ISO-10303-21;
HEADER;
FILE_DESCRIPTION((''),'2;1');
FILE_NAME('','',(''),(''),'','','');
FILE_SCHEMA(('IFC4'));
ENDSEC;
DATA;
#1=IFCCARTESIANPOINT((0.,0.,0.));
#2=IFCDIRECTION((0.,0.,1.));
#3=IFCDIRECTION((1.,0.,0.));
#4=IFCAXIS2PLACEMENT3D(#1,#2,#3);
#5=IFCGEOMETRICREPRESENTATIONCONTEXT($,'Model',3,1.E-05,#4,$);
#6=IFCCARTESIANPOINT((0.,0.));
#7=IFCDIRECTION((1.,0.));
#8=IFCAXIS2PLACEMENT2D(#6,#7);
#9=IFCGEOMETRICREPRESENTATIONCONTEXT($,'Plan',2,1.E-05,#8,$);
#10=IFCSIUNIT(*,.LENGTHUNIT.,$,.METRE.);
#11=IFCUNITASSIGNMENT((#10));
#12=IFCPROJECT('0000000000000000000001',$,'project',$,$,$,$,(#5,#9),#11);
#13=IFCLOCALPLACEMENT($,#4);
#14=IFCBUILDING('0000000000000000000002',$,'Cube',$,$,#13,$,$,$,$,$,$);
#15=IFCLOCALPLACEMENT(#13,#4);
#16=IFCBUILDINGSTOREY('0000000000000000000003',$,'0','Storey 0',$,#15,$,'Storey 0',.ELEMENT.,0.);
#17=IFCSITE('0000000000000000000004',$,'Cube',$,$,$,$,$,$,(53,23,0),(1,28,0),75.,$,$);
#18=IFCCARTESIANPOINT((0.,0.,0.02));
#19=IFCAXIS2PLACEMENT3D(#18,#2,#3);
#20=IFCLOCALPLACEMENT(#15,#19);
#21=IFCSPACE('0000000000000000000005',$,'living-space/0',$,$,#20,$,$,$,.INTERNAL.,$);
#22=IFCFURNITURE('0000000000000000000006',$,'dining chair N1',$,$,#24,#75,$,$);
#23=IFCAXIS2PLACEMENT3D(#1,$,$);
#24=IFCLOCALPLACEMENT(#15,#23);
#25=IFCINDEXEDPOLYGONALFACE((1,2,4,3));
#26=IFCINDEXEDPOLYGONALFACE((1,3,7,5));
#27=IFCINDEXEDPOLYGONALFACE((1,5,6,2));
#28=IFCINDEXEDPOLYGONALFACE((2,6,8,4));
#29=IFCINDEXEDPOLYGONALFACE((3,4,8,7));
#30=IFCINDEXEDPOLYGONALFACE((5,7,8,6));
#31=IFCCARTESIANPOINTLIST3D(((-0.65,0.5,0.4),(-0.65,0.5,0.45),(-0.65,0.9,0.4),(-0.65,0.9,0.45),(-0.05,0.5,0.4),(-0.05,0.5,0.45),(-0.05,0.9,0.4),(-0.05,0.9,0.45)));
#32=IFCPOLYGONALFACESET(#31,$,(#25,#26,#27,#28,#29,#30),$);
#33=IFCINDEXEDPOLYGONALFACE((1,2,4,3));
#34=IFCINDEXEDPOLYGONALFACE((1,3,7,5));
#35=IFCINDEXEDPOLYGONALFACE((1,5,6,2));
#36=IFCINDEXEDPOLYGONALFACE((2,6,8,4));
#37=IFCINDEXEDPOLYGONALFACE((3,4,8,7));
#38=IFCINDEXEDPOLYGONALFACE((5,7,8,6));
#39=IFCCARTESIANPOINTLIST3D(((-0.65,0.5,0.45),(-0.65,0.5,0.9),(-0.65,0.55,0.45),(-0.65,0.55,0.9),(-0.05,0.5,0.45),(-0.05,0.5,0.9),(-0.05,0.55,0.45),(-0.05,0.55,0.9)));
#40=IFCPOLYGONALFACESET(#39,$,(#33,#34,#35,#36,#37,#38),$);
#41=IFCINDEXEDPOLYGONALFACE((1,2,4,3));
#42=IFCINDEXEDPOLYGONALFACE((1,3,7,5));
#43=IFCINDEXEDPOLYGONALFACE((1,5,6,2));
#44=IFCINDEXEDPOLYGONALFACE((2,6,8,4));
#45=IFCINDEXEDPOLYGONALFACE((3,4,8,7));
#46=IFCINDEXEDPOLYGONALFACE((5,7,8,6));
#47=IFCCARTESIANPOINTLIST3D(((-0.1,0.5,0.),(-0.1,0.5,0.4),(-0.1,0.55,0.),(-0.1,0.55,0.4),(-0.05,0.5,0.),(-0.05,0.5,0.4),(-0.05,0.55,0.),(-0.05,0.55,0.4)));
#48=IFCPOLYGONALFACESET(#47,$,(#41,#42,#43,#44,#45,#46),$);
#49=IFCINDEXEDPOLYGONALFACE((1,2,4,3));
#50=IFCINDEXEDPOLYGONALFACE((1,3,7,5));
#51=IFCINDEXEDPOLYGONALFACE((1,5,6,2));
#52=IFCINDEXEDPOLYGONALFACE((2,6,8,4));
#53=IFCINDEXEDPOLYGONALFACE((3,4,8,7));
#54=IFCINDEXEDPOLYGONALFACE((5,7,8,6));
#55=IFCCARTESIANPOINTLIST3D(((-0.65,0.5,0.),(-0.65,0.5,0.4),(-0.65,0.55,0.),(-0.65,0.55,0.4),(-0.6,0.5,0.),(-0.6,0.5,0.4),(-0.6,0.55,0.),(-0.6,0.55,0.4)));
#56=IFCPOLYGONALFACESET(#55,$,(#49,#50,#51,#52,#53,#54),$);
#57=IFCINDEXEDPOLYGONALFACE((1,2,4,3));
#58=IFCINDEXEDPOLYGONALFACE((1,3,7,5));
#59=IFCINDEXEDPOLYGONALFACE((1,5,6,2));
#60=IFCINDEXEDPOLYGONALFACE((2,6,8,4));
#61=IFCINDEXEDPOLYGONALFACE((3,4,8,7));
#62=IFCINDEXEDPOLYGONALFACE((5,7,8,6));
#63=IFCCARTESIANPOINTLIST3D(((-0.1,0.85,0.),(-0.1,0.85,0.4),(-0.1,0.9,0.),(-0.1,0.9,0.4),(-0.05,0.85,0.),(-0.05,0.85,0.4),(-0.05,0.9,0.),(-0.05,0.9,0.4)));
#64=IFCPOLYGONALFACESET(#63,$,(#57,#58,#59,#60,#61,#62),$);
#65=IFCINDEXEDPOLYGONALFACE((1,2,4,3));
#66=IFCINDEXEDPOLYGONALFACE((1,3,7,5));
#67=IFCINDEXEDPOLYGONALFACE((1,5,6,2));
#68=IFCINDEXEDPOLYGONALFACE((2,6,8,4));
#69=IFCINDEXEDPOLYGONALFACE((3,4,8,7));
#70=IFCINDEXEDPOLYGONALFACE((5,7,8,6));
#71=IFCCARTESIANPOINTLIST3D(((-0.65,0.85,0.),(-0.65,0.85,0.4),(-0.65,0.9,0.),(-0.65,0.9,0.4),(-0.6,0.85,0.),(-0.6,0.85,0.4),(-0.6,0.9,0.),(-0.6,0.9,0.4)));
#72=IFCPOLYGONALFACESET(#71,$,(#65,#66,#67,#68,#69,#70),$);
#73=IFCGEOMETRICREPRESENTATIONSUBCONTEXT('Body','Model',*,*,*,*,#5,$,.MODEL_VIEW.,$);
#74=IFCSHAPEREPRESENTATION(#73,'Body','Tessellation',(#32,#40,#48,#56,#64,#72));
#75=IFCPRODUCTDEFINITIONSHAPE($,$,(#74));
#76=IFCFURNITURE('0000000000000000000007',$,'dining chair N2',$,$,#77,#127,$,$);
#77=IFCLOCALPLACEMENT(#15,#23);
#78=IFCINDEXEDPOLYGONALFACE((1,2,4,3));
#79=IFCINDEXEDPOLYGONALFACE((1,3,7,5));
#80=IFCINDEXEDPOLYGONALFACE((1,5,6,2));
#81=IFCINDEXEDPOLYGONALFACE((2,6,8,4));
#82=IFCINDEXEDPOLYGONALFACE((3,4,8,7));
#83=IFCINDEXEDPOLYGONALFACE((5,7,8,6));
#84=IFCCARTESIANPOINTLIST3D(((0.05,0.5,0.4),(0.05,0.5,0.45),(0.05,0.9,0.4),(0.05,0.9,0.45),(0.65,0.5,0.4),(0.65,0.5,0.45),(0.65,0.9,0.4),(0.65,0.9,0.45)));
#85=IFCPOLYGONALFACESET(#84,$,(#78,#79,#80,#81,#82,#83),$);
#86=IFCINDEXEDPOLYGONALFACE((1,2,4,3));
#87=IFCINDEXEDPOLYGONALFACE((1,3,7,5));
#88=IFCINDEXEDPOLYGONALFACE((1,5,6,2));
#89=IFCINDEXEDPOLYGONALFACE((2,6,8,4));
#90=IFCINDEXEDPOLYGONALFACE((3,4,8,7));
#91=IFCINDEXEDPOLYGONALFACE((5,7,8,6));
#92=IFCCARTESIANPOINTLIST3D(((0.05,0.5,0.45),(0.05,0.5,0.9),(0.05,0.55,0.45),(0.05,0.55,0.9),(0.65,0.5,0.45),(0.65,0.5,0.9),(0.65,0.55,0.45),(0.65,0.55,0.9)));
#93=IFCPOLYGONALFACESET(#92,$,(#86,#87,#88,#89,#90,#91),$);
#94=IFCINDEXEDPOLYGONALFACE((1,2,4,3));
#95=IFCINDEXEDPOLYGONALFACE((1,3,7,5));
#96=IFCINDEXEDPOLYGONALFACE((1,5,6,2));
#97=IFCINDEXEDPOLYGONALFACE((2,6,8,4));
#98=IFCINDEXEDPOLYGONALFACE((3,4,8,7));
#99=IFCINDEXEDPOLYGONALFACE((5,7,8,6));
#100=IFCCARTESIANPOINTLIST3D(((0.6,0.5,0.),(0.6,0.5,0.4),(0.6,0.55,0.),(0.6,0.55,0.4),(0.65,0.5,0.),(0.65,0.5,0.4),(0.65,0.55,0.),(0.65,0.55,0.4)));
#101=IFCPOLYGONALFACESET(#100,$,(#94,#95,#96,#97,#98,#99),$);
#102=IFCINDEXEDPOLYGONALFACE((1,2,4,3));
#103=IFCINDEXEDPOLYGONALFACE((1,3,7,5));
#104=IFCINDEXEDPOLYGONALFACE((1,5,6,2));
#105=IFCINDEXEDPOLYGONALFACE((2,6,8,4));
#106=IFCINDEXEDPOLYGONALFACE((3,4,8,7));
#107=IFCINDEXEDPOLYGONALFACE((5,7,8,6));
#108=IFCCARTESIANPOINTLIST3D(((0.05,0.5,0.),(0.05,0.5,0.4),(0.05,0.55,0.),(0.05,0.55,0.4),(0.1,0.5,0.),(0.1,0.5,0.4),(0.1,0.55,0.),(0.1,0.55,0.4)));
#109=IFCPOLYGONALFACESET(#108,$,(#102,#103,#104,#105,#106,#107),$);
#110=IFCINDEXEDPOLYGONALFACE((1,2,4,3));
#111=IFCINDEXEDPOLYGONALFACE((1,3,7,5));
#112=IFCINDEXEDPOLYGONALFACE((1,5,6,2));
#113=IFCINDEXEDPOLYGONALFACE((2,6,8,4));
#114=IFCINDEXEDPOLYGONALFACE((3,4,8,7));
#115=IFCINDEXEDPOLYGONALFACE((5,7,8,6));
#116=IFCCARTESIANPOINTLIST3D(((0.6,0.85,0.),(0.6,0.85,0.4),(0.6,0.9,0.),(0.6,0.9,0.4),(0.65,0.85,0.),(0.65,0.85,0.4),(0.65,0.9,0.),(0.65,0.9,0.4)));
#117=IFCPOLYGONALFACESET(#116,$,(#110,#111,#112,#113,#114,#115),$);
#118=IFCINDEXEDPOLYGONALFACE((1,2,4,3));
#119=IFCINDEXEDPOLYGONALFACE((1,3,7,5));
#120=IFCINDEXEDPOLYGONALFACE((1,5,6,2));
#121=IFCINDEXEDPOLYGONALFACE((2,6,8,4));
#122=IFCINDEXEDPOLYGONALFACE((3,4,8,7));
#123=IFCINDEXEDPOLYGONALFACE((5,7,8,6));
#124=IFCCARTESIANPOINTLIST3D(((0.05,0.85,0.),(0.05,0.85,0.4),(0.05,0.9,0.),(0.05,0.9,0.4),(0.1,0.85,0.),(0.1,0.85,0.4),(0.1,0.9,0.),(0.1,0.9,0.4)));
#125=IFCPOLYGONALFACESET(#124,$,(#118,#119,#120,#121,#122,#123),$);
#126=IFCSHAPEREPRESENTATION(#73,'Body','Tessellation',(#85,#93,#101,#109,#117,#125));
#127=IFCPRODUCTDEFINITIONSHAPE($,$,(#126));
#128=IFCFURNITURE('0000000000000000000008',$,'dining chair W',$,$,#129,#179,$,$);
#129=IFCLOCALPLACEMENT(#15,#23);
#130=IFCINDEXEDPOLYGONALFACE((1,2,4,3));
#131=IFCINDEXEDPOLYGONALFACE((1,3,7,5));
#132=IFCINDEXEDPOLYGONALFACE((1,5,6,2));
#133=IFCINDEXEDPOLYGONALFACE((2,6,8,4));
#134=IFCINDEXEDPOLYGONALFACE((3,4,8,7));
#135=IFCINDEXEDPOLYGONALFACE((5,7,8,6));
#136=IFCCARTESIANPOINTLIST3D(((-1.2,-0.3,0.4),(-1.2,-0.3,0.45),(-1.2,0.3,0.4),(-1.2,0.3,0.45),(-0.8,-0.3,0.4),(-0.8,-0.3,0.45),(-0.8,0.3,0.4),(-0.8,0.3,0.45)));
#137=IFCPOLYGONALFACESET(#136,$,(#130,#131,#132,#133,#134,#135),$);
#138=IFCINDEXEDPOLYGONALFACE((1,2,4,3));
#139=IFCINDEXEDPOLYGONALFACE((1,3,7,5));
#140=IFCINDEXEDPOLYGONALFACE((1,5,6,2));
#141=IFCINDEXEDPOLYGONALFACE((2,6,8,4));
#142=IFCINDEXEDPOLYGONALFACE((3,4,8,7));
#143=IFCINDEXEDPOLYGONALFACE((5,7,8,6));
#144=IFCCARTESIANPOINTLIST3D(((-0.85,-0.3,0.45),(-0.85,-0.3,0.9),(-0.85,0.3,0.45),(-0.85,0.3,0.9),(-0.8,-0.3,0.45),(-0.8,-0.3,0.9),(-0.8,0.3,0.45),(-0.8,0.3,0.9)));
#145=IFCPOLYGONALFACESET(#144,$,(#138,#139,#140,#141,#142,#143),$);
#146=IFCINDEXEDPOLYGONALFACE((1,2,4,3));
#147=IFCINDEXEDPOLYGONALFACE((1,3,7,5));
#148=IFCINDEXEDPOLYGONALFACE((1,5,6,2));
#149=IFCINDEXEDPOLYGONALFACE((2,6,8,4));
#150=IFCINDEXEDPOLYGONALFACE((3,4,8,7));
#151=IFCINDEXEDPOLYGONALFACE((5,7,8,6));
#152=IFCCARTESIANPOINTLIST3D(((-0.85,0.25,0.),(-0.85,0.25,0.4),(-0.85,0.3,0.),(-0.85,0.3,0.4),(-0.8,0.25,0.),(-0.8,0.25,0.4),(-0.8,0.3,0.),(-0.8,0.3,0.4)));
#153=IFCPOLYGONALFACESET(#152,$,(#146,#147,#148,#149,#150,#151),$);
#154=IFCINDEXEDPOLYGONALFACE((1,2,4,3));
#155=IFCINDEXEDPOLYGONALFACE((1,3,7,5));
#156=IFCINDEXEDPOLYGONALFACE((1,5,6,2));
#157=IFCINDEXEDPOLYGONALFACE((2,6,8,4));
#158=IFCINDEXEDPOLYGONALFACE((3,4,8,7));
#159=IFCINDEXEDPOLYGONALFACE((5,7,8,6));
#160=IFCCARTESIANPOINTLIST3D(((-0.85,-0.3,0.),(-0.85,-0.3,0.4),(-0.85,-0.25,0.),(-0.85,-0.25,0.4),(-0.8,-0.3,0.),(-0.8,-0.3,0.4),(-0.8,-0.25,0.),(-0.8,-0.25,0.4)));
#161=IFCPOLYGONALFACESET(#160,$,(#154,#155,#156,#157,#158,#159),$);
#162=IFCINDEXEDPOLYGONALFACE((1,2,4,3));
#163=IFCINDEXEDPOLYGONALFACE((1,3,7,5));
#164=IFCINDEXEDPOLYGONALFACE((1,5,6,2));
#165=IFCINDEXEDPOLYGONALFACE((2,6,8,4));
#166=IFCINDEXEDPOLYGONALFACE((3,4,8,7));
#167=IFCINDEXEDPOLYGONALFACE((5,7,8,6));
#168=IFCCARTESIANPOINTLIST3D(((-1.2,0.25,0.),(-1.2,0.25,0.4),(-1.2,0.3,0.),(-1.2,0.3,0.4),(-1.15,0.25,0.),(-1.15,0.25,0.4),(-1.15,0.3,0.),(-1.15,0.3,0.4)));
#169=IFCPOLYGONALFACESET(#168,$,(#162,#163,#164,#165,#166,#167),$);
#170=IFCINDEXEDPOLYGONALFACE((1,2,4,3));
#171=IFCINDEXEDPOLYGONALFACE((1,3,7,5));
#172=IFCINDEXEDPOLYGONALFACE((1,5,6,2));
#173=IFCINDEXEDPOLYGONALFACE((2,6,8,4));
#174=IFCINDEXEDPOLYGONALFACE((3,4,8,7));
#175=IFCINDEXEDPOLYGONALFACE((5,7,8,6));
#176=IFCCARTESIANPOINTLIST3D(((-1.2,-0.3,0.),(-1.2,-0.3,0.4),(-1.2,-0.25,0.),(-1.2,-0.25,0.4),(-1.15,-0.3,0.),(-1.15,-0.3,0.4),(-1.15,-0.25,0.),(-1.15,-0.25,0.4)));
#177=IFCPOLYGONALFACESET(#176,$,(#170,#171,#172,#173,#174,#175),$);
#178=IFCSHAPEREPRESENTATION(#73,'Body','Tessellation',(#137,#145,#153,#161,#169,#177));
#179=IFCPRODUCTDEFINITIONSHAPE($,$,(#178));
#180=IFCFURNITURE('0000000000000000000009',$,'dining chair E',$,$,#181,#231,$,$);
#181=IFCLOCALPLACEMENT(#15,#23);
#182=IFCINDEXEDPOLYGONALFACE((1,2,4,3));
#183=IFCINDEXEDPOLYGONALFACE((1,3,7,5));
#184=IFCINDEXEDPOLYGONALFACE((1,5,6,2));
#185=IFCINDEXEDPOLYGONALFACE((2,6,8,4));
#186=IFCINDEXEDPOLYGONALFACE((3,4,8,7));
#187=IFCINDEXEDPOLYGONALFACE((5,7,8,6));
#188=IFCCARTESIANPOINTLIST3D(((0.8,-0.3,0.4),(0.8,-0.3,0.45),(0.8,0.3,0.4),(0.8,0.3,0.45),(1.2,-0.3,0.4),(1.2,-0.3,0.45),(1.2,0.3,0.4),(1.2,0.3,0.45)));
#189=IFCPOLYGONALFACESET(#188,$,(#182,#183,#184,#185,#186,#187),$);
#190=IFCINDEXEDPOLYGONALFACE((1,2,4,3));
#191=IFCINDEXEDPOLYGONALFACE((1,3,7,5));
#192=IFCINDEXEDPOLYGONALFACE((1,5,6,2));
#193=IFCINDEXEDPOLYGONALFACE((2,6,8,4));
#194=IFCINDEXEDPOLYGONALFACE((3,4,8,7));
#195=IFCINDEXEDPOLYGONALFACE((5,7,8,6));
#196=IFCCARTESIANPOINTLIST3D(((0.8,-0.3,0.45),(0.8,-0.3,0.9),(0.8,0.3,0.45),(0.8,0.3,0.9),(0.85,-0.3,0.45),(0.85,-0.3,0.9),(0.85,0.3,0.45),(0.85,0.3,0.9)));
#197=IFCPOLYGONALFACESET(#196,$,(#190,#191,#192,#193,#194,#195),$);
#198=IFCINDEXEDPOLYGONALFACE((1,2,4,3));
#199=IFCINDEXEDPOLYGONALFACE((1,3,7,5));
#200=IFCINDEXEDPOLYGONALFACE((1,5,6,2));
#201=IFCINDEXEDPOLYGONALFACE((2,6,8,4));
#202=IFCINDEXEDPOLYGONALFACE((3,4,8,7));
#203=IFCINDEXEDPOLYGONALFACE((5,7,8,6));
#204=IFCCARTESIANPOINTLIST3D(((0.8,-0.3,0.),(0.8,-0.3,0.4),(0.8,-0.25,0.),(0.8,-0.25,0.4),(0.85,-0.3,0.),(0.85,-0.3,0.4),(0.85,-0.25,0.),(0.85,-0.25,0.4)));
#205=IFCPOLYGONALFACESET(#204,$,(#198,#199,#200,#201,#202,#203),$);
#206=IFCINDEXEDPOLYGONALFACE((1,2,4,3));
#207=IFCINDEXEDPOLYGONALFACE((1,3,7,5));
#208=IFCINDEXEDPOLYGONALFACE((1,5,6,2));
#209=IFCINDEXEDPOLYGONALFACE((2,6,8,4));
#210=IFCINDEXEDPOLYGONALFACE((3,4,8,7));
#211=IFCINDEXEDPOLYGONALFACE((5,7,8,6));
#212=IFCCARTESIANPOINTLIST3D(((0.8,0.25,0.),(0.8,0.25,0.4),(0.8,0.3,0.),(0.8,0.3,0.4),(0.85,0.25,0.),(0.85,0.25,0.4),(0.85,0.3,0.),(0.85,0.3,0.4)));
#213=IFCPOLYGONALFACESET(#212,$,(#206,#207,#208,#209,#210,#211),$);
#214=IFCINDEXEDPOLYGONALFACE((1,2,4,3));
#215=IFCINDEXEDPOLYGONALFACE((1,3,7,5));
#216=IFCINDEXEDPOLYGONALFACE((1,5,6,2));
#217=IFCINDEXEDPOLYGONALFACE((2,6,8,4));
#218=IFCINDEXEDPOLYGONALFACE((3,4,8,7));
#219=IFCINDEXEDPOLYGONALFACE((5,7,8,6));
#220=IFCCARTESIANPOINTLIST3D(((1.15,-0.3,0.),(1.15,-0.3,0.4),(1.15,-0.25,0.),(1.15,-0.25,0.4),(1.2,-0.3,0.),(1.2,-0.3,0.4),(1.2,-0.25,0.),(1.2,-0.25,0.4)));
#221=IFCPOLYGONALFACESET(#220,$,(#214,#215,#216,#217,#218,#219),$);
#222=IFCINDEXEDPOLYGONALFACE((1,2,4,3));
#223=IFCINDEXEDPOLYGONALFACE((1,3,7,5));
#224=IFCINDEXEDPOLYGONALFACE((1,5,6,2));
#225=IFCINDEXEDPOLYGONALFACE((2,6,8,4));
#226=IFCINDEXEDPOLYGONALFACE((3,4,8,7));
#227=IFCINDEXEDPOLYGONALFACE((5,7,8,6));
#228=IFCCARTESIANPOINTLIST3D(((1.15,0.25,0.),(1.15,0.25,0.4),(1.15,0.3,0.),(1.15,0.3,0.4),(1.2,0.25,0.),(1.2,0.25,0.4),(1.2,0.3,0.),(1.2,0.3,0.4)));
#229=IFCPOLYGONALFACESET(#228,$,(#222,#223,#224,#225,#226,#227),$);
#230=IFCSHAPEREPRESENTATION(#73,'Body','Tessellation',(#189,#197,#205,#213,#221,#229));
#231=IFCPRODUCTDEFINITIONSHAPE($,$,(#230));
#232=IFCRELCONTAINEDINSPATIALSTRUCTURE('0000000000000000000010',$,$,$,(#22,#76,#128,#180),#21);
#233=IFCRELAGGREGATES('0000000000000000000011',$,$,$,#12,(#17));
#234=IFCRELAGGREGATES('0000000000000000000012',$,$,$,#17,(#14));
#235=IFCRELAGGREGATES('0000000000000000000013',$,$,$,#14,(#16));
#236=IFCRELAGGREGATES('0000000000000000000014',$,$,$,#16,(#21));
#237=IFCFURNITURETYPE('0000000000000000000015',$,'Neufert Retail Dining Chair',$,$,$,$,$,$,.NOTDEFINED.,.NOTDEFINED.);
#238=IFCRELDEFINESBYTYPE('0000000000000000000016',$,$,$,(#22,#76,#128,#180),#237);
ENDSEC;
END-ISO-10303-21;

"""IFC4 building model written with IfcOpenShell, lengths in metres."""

from ifc_helpers import new_model, entity, si_unit, frame, origin_with_axes, origin_2d_with_axis, place, context, subcontext, project, spatial, line, indexed_curve, outline, extrude, shape, source, transform, mapped, type_object, type_shapes, element, save


model = new_model("IFC4")

# Units and contexts
model_context = context("Model", 3, precision=1e-05, world=origin_with_axes())
plan_context = context("Plan", 2, precision=1e-05, world=origin_2d_with_axis())
body_context_1 = subcontext(model_context, "Body", "Model", "MODEL_VIEW")
body_context_2 = subcontext(plan_context, "Body", "Plan", "PLAN_VIEW")
ifc_project = project(units=[si_unit("LENGTHUNIT", "METRE")], contexts=[model_context, plan_context])

# Site, building, storey
site = spatial("IfcSite", under=ifc_project, Name="Cube", RefLatitude=(53, 23, 0), RefLongitude=(1, 28, 0), RefElevation=75.0)
building_placement = place(None, origin_with_axes())
building = spatial("IfcBuilding", under=site, at=building_placement, Name="Cube")
storey_placement = place(building_placement, origin_with_axes())
storey = spatial("IfcBuildingStorey", under=building, at=storey_placement, Name="0", Description="Storey 0", LongName="Storey 0", CompositionType="ELEMENT", Elevation=0.0)

# Shared definitions
space_placement = place(storey_placement, frame((0.0, 0.0, 0.02), z_axis=(0.0, 0.0, 1.0), x_axis=(1.0, 0.0, 0.0)))
space = spatial("IfcSpace", under=storey, at=space_placement, Name="living-space/0", PredefinedType="INTERNAL")

# Furniture
furniture_type_1 = type_object("IfcFurnitureType", Name="Neufert Retail Dining Chair", AssemblyPlace="NOTDEFINED", PredefinedType="NOTDEFINED")
shared_shape_1 = source(origin_with_axes(), body_context_1, "Body", "SweptSolid", [
    extrude(outline(indexed_curve([(-0.3, 0.0), (0.3, 0.0), (0.3, -0.4), (-0.3, -0.4)], segments=[line(1, 2, 3, 4, 1)])), frame((0.0, 0.0, 0.45), z_axis=(0.0, 0.0, 1.0), x_axis=(1.0, 0.0, 0.0)), (0.0, 0.0, -1.0), 0.05),
    extrude(outline(indexed_curve([(-0.3, 0.0), (0.3, 0.0), (0.3, -0.05), (-0.3, -0.05)], segments=[line(1, 2, 3, 4, 1)])), frame((0.0, 0.0, 0.9), z_axis=(0.0, 0.0, 1.0), x_axis=(1.0, 0.0, 0.0)), (0.0, 0.0, -1.0), 0.45),
    extrude(outline(indexed_curve([(-0.3, 0.0), (-0.25, 0.0), (-0.25, -0.05), (-0.3, -0.05)], segments=[line(1, 2, 3, 4, 1)])), origin_with_axes(), (0.0, 0.0, 1.0), 0.4),
    extrude(outline(indexed_curve([(0.3, 0.0), (0.25, 0.0), (0.25, -0.05), (0.3, -0.05)], segments=[line(1, 2, 3, 4, 1)])), origin_with_axes(), (0.0, 0.0, 1.0), 0.4),
    extrude(outline(indexed_curve([(-0.3, -0.4), (-0.25, -0.4), (-0.25, -0.35), (-0.3, -0.35)], segments=[line(1, 2, 3, 4, 1)])), origin_with_axes(), (0.0, 0.0, 1.0), 0.4),
    extrude(outline(indexed_curve([(0.3, -0.4), (0.25, -0.4), (0.25, -0.35), (0.3, -0.35)], segments=[line(1, 2, 3, 4, 1)])), origin_with_axes(), (0.0, 0.0, 1.0), 0.4),
])
shared_shape_2 = source(origin_with_axes(), body_context_2, "Body", "Curve2D", [
    entity("IfcIndexedPolyCurve", entity("IfcCartesianPointList2D", [[-0.3, -0.4], [0.3, -0.4]])),
    entity("IfcIndexedPolyCurve", entity("IfcCartesianPointList2D", [[-0.3, -0.4], [-0.3, -0.3], [-0.2121, -0.0879], [0.0, 0.0], [0.2121, -0.0879], [0.3, -0.3], [0.3, -0.4]]), [entity("IfcLineIndex", [1, 2]), entity("IfcArcIndex", [2, 3, 4]), entity("IfcArcIndex", [4, 5, 6]), entity("IfcLineIndex", [6, 7])]),
    entity("IfcIndexedPolyCurve", entity("IfcCartesianPointList2D", [[-0.26, -0.4], [-0.26, -0.3], [-0.1838, -0.1162], [0.0, -0.04], [0.1838, -0.1162], [0.26, -0.3], [0.26, -0.4]]), [entity("IfcLineIndex", [1, 2]), entity("IfcArcIndex", [2, 3, 4]), entity("IfcArcIndex", [4, 5, 6]), entity("IfcLineIndex", [6, 7])]),
])
type_shapes(furniture_type_1, [shared_shape_1, shared_shape_2])
for number, where, z_axis, x_axis, name in (
    (1, (-0.35, 0.5, -0.02), (0.0, 0.0, 1.0), (-1.0, 0.0, 0.0), "dining chair N1"),
    (2, (0.35, 0.5, -0.02), (0.0, 0.0, 1.0), (-1.0, 0.0, 0.0), "dining chair N2"),
    (3, (-0.8, 0.0, -0.02), (0.0, 0.0, 1.0), (0.0, -1.0, 0.0), "dining chair W"),
    (4, (0.8, 0.0, -0.02), (0.0, 0.0, 1.0), (0.0, 1.0, 0.0), "dining chair E"),
):
    element("IfcFurniture", number, at=place(space_placement, frame(where, z_axis=z_axis, x_axis=x_axis)), inside=space, type_object=furniture_type_1, Name=name, shapes=[
        shape(body_context_1, "Body", "MappedRepresentation", [mapped(shared_shape_1, transform((0.0, 0.0, 0.0), x_axis=(1.0, 0.0, 0.0), y_axis=(0.0, 1.0, 0.0), z_axis=(0.0, 0.0, 1.0), scale=1.0))]),
        shape(body_context_2, "Body", "MappedRepresentation", [mapped(shared_shape_2, transform((0.0, 0.0, 0.0), x_axis=(1.0, 0.0, 0.0), y_axis=(0.0, 1.0, 0.0), z_axis=(0.0, 0.0, 1.0), scale=1.0))]),
    ])

save(model, "model.ifc")
